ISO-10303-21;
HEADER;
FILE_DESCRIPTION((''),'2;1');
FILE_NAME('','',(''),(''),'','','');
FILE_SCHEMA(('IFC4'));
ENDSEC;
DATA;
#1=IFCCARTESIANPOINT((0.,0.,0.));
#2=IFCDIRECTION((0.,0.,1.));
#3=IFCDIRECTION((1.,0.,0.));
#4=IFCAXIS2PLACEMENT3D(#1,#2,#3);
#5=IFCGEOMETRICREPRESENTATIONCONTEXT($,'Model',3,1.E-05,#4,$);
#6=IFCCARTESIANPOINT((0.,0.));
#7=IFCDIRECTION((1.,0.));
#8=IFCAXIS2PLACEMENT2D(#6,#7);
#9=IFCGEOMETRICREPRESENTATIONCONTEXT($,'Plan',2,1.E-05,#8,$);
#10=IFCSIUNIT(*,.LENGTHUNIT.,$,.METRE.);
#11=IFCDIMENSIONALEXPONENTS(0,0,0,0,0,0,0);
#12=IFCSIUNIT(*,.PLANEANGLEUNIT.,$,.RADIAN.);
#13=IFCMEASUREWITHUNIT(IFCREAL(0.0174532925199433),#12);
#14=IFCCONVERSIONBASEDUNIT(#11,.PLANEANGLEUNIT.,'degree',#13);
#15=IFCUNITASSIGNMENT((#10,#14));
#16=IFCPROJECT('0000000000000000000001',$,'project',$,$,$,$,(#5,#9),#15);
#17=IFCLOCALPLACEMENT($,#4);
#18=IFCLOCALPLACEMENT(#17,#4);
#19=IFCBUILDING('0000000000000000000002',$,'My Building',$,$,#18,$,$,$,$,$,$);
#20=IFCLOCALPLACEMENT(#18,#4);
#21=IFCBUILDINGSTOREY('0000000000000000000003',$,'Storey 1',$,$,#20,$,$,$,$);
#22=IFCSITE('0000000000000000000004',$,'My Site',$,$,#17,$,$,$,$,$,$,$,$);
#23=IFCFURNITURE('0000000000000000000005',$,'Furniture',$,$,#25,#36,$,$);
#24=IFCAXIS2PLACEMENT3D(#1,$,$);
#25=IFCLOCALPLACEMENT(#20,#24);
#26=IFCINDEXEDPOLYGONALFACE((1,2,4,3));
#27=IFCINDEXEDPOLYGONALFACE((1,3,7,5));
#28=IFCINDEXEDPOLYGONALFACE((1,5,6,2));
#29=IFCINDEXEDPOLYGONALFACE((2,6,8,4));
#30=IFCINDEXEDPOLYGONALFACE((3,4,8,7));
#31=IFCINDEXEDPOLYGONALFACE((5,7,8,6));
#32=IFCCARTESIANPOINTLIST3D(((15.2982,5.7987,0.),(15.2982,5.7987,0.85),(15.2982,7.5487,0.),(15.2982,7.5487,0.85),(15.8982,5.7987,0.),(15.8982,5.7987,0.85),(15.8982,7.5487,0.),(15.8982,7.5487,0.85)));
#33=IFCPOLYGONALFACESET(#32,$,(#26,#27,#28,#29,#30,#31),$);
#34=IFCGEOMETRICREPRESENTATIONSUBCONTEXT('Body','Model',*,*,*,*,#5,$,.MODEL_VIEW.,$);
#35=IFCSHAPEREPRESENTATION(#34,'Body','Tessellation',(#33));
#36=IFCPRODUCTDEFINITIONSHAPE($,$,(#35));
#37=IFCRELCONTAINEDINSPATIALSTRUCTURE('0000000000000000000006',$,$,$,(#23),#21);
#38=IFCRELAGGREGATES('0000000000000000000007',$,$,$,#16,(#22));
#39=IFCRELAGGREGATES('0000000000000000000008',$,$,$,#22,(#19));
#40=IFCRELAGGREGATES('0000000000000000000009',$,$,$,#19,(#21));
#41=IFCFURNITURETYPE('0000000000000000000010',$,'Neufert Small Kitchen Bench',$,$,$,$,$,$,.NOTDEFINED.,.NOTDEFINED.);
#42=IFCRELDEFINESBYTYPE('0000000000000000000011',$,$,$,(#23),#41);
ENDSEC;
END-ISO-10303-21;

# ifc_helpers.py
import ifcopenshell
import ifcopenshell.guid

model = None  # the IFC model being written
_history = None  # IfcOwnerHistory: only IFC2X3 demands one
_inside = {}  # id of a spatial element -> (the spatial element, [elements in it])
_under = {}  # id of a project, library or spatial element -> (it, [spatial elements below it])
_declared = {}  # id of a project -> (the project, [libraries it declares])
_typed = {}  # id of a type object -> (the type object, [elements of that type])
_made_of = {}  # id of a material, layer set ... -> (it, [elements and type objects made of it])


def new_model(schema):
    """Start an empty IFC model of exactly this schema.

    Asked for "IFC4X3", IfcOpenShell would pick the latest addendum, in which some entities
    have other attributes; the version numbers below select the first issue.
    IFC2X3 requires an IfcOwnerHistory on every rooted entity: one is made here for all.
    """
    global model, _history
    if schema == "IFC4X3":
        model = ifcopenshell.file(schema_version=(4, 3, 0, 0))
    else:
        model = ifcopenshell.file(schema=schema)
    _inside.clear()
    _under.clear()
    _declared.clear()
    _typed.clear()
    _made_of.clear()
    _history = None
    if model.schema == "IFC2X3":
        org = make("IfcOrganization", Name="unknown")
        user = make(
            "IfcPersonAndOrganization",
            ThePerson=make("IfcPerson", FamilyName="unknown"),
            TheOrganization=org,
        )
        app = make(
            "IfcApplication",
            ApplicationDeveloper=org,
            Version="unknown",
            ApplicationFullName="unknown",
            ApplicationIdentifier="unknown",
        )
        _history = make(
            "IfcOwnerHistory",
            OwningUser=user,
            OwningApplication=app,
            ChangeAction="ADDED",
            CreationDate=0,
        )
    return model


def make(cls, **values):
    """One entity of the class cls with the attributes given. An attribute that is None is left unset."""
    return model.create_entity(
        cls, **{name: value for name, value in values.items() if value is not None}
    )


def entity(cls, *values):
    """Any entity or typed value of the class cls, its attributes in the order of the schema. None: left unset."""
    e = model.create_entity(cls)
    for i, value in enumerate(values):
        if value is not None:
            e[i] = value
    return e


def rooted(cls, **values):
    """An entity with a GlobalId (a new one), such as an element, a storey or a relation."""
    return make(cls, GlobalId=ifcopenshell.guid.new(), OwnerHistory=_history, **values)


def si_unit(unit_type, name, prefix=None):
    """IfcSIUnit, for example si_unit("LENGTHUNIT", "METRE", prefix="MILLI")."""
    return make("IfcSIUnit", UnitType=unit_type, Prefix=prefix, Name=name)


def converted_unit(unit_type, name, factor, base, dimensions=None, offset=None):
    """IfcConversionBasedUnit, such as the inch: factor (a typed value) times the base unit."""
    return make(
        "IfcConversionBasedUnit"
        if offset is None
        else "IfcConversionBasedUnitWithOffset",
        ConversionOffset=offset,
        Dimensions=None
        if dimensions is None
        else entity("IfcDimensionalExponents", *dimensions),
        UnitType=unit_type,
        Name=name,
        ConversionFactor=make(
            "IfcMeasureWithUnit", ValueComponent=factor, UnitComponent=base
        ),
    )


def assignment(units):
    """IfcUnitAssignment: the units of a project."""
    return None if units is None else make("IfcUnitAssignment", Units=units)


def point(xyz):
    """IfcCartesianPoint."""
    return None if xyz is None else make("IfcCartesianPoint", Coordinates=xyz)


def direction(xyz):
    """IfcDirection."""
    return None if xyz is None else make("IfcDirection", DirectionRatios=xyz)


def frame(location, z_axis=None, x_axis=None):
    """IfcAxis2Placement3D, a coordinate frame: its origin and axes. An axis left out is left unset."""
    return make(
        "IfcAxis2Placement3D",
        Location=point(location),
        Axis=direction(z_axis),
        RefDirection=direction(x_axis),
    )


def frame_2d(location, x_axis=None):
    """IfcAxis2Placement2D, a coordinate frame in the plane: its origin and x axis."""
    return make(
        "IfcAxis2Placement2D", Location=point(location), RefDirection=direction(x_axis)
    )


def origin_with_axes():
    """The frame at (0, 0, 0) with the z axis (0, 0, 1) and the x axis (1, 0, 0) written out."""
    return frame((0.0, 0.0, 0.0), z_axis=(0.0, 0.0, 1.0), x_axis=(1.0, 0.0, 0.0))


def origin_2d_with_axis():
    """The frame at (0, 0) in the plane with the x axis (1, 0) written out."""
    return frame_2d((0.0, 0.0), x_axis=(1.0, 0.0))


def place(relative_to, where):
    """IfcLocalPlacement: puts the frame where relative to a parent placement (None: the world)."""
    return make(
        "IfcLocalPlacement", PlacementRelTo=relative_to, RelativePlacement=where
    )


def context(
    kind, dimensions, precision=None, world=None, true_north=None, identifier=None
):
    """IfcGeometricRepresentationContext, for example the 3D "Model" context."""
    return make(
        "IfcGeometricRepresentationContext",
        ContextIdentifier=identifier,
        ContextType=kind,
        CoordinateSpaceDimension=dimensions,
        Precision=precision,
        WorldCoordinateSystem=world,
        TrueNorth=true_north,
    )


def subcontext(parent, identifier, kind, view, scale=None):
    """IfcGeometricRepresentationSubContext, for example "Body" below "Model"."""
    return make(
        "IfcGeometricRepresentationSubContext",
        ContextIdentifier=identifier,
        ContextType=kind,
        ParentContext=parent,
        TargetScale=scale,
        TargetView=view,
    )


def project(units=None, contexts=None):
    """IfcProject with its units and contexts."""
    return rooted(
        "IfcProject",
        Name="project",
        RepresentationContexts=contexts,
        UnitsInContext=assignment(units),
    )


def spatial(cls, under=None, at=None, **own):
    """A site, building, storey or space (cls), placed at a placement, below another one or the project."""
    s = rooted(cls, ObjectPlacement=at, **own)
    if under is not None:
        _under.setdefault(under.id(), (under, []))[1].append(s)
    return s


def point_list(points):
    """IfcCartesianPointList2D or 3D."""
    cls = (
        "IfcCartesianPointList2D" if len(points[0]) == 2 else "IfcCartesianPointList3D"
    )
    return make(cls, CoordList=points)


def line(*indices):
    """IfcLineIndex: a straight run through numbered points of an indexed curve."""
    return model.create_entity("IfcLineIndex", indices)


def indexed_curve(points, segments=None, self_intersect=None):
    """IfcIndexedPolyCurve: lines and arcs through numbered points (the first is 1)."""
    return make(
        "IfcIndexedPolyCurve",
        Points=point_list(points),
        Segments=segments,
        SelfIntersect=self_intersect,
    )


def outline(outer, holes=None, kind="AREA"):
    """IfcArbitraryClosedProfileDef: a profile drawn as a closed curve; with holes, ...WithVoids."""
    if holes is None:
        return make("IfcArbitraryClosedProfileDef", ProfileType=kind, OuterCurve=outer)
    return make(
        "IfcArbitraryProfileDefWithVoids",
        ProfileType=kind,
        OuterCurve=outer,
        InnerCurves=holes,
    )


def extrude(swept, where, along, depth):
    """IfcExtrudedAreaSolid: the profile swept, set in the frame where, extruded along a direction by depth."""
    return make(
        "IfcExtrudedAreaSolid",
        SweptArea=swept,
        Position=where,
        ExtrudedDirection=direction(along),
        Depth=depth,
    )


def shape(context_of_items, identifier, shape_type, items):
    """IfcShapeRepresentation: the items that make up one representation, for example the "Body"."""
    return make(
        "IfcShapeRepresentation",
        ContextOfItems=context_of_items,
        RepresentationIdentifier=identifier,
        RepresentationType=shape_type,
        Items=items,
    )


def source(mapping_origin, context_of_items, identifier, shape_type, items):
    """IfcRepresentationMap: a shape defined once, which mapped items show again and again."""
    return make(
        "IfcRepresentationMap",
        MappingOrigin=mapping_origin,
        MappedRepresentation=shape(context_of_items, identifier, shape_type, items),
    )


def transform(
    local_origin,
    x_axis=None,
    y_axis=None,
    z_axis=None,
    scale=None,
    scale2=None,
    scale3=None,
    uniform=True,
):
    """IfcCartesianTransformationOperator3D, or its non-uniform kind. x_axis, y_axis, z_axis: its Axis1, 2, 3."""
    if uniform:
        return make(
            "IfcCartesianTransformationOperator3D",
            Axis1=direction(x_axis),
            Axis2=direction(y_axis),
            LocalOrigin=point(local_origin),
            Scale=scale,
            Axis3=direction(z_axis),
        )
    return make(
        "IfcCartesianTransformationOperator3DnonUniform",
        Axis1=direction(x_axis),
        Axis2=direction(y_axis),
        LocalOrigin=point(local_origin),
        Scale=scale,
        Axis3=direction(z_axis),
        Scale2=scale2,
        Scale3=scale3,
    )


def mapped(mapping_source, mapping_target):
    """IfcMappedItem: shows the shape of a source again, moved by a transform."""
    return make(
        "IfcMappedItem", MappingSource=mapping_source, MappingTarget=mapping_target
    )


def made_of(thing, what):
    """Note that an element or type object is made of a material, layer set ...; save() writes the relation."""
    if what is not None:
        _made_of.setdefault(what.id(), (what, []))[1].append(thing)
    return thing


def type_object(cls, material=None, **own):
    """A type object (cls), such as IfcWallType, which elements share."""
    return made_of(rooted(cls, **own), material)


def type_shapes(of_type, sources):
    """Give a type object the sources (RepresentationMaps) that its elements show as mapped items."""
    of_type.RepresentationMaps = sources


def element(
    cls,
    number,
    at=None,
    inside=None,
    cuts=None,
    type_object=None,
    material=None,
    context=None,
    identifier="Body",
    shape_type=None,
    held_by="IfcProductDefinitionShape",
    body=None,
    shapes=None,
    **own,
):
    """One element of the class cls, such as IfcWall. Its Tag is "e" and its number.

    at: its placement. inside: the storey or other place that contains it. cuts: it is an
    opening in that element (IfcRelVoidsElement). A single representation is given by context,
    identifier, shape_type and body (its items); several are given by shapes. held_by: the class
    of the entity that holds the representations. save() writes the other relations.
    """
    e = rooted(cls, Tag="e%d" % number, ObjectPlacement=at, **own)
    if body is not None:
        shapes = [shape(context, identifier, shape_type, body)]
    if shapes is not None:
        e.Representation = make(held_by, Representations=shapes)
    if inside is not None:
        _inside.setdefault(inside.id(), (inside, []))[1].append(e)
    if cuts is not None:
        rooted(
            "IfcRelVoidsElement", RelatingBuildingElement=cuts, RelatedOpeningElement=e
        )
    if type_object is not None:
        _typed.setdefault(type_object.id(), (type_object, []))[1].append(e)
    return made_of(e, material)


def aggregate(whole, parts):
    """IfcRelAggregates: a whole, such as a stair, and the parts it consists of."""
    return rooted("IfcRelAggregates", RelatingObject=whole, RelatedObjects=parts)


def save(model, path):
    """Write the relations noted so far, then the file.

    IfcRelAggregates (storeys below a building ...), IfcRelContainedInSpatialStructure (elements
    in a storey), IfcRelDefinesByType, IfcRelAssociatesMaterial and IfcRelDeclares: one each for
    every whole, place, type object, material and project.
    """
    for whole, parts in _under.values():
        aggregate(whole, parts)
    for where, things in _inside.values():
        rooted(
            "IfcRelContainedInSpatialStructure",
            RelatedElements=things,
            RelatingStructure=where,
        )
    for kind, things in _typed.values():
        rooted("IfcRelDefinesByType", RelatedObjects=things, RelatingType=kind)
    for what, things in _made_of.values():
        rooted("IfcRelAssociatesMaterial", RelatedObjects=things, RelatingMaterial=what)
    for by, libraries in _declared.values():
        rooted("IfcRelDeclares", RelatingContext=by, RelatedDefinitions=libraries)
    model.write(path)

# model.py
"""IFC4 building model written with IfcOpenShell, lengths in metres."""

from ifc_helpers import new_model, entity, si_unit, converted_unit, frame, origin_with_axes, origin_2d_with_axis, place, context, subcontext, project, spatial, line, indexed_curve, outline, extrude, shape, source, transform, mapped, type_object, type_shapes, element, save


model = new_model("IFC4")

# Units and contexts
model_context = context("Model", 3, precision=1e-05, world=origin_with_axes())
plan_context = context("Plan", 2, precision=1e-05, world=origin_2d_with_axis())
body_context_1 = subcontext(model_context, "Body", "Model", "MODEL_VIEW")
body_context_2 = subcontext(plan_context, "Body", "Plan", "PLAN_VIEW")
ifc_project = project(units=[si_unit("LENGTHUNIT", "METRE"), converted_unit("PLANEANGLEUNIT", "degree", entity("IfcReal", 0.0174532925199433), si_unit("PLANEANGLEUNIT", "RADIAN"), dimensions=[0, 0, 0, 0, 0, 0, 0])], contexts=[model_context, plan_context])

# Site, building, storey
site_placement = place(None, origin_with_axes())
site = spatial("IfcSite", under=ifc_project, at=site_placement, Name="My Site")
building_placement = place(site_placement, origin_with_axes())
building = spatial("IfcBuilding", under=site, at=building_placement, Name="My Building")
storey_placement = place(building_placement, origin_with_axes())
storey = spatial("IfcBuildingStorey", under=building, at=storey_placement, Name="Storey 1")

# Furniture
furniture_type_1 = type_object("IfcFurnitureType", Name="Neufert Small Kitchen Bench", AssemblyPlace="NOTDEFINED", PredefinedType="NOTDEFINED")
shared_shape_1 = source(origin_with_axes(), body_context_1, "Body", "SweptSolid", [
    extrude(outline(indexed_curve([(0.0, 0.0), (1.75, 0.0), (1.75, 0.6), (0.0, 0.6)], segments=[line(1, 2, 3, 4, 1)])), origin_with_axes(), (0.0, 0.0, 1.0), 0.85),
])
shared_shape_2 = source(origin_with_axes(), body_context_2, "Body", "Curve2D", [
    entity("IfcIndexedPolyCurve", entity("IfcCartesianPointList2D", [[0.0, 0.0], [1.75, 0.0], [1.75, 0.6], [0.0, 0.6]]), [entity("IfcLineIndex", [1, 2, 3, 4, 1])]),
])
type_shapes(furniture_type_1, [shared_shape_1, shared_shape_2])
furniture_placement = place(storey_placement, frame((15.2982, 7.5487, 0.0), z_axis=(0.0, 0.0, 1.0), x_axis=(0.0, -1.0, 0.0)))
element("IfcFurniture", 1, at=furniture_placement, inside=storey, type_object=furniture_type_1, Name="Furniture", shapes=[
    shape(body_context_1, "Body", "MappedRepresentation", [mapped(shared_shape_1, transform((0.0, 0.0, 0.0), x_axis=(1.0, 0.0, 0.0), y_axis=(0.0, 1.0, 0.0), z_axis=(0.0, 0.0, 1.0), scale=1.0))]),
    shape(body_context_2, "Body", "MappedRepresentation", [mapped(shared_shape_2, transform((0.0, 0.0, 0.0), x_axis=(1.0, 0.0, 0.0), y_axis=(0.0, 1.0, 0.0), z_axis=(0.0, 0.0, 1.0), scale=1.0))]),
])

save(model, "model.ifc")
